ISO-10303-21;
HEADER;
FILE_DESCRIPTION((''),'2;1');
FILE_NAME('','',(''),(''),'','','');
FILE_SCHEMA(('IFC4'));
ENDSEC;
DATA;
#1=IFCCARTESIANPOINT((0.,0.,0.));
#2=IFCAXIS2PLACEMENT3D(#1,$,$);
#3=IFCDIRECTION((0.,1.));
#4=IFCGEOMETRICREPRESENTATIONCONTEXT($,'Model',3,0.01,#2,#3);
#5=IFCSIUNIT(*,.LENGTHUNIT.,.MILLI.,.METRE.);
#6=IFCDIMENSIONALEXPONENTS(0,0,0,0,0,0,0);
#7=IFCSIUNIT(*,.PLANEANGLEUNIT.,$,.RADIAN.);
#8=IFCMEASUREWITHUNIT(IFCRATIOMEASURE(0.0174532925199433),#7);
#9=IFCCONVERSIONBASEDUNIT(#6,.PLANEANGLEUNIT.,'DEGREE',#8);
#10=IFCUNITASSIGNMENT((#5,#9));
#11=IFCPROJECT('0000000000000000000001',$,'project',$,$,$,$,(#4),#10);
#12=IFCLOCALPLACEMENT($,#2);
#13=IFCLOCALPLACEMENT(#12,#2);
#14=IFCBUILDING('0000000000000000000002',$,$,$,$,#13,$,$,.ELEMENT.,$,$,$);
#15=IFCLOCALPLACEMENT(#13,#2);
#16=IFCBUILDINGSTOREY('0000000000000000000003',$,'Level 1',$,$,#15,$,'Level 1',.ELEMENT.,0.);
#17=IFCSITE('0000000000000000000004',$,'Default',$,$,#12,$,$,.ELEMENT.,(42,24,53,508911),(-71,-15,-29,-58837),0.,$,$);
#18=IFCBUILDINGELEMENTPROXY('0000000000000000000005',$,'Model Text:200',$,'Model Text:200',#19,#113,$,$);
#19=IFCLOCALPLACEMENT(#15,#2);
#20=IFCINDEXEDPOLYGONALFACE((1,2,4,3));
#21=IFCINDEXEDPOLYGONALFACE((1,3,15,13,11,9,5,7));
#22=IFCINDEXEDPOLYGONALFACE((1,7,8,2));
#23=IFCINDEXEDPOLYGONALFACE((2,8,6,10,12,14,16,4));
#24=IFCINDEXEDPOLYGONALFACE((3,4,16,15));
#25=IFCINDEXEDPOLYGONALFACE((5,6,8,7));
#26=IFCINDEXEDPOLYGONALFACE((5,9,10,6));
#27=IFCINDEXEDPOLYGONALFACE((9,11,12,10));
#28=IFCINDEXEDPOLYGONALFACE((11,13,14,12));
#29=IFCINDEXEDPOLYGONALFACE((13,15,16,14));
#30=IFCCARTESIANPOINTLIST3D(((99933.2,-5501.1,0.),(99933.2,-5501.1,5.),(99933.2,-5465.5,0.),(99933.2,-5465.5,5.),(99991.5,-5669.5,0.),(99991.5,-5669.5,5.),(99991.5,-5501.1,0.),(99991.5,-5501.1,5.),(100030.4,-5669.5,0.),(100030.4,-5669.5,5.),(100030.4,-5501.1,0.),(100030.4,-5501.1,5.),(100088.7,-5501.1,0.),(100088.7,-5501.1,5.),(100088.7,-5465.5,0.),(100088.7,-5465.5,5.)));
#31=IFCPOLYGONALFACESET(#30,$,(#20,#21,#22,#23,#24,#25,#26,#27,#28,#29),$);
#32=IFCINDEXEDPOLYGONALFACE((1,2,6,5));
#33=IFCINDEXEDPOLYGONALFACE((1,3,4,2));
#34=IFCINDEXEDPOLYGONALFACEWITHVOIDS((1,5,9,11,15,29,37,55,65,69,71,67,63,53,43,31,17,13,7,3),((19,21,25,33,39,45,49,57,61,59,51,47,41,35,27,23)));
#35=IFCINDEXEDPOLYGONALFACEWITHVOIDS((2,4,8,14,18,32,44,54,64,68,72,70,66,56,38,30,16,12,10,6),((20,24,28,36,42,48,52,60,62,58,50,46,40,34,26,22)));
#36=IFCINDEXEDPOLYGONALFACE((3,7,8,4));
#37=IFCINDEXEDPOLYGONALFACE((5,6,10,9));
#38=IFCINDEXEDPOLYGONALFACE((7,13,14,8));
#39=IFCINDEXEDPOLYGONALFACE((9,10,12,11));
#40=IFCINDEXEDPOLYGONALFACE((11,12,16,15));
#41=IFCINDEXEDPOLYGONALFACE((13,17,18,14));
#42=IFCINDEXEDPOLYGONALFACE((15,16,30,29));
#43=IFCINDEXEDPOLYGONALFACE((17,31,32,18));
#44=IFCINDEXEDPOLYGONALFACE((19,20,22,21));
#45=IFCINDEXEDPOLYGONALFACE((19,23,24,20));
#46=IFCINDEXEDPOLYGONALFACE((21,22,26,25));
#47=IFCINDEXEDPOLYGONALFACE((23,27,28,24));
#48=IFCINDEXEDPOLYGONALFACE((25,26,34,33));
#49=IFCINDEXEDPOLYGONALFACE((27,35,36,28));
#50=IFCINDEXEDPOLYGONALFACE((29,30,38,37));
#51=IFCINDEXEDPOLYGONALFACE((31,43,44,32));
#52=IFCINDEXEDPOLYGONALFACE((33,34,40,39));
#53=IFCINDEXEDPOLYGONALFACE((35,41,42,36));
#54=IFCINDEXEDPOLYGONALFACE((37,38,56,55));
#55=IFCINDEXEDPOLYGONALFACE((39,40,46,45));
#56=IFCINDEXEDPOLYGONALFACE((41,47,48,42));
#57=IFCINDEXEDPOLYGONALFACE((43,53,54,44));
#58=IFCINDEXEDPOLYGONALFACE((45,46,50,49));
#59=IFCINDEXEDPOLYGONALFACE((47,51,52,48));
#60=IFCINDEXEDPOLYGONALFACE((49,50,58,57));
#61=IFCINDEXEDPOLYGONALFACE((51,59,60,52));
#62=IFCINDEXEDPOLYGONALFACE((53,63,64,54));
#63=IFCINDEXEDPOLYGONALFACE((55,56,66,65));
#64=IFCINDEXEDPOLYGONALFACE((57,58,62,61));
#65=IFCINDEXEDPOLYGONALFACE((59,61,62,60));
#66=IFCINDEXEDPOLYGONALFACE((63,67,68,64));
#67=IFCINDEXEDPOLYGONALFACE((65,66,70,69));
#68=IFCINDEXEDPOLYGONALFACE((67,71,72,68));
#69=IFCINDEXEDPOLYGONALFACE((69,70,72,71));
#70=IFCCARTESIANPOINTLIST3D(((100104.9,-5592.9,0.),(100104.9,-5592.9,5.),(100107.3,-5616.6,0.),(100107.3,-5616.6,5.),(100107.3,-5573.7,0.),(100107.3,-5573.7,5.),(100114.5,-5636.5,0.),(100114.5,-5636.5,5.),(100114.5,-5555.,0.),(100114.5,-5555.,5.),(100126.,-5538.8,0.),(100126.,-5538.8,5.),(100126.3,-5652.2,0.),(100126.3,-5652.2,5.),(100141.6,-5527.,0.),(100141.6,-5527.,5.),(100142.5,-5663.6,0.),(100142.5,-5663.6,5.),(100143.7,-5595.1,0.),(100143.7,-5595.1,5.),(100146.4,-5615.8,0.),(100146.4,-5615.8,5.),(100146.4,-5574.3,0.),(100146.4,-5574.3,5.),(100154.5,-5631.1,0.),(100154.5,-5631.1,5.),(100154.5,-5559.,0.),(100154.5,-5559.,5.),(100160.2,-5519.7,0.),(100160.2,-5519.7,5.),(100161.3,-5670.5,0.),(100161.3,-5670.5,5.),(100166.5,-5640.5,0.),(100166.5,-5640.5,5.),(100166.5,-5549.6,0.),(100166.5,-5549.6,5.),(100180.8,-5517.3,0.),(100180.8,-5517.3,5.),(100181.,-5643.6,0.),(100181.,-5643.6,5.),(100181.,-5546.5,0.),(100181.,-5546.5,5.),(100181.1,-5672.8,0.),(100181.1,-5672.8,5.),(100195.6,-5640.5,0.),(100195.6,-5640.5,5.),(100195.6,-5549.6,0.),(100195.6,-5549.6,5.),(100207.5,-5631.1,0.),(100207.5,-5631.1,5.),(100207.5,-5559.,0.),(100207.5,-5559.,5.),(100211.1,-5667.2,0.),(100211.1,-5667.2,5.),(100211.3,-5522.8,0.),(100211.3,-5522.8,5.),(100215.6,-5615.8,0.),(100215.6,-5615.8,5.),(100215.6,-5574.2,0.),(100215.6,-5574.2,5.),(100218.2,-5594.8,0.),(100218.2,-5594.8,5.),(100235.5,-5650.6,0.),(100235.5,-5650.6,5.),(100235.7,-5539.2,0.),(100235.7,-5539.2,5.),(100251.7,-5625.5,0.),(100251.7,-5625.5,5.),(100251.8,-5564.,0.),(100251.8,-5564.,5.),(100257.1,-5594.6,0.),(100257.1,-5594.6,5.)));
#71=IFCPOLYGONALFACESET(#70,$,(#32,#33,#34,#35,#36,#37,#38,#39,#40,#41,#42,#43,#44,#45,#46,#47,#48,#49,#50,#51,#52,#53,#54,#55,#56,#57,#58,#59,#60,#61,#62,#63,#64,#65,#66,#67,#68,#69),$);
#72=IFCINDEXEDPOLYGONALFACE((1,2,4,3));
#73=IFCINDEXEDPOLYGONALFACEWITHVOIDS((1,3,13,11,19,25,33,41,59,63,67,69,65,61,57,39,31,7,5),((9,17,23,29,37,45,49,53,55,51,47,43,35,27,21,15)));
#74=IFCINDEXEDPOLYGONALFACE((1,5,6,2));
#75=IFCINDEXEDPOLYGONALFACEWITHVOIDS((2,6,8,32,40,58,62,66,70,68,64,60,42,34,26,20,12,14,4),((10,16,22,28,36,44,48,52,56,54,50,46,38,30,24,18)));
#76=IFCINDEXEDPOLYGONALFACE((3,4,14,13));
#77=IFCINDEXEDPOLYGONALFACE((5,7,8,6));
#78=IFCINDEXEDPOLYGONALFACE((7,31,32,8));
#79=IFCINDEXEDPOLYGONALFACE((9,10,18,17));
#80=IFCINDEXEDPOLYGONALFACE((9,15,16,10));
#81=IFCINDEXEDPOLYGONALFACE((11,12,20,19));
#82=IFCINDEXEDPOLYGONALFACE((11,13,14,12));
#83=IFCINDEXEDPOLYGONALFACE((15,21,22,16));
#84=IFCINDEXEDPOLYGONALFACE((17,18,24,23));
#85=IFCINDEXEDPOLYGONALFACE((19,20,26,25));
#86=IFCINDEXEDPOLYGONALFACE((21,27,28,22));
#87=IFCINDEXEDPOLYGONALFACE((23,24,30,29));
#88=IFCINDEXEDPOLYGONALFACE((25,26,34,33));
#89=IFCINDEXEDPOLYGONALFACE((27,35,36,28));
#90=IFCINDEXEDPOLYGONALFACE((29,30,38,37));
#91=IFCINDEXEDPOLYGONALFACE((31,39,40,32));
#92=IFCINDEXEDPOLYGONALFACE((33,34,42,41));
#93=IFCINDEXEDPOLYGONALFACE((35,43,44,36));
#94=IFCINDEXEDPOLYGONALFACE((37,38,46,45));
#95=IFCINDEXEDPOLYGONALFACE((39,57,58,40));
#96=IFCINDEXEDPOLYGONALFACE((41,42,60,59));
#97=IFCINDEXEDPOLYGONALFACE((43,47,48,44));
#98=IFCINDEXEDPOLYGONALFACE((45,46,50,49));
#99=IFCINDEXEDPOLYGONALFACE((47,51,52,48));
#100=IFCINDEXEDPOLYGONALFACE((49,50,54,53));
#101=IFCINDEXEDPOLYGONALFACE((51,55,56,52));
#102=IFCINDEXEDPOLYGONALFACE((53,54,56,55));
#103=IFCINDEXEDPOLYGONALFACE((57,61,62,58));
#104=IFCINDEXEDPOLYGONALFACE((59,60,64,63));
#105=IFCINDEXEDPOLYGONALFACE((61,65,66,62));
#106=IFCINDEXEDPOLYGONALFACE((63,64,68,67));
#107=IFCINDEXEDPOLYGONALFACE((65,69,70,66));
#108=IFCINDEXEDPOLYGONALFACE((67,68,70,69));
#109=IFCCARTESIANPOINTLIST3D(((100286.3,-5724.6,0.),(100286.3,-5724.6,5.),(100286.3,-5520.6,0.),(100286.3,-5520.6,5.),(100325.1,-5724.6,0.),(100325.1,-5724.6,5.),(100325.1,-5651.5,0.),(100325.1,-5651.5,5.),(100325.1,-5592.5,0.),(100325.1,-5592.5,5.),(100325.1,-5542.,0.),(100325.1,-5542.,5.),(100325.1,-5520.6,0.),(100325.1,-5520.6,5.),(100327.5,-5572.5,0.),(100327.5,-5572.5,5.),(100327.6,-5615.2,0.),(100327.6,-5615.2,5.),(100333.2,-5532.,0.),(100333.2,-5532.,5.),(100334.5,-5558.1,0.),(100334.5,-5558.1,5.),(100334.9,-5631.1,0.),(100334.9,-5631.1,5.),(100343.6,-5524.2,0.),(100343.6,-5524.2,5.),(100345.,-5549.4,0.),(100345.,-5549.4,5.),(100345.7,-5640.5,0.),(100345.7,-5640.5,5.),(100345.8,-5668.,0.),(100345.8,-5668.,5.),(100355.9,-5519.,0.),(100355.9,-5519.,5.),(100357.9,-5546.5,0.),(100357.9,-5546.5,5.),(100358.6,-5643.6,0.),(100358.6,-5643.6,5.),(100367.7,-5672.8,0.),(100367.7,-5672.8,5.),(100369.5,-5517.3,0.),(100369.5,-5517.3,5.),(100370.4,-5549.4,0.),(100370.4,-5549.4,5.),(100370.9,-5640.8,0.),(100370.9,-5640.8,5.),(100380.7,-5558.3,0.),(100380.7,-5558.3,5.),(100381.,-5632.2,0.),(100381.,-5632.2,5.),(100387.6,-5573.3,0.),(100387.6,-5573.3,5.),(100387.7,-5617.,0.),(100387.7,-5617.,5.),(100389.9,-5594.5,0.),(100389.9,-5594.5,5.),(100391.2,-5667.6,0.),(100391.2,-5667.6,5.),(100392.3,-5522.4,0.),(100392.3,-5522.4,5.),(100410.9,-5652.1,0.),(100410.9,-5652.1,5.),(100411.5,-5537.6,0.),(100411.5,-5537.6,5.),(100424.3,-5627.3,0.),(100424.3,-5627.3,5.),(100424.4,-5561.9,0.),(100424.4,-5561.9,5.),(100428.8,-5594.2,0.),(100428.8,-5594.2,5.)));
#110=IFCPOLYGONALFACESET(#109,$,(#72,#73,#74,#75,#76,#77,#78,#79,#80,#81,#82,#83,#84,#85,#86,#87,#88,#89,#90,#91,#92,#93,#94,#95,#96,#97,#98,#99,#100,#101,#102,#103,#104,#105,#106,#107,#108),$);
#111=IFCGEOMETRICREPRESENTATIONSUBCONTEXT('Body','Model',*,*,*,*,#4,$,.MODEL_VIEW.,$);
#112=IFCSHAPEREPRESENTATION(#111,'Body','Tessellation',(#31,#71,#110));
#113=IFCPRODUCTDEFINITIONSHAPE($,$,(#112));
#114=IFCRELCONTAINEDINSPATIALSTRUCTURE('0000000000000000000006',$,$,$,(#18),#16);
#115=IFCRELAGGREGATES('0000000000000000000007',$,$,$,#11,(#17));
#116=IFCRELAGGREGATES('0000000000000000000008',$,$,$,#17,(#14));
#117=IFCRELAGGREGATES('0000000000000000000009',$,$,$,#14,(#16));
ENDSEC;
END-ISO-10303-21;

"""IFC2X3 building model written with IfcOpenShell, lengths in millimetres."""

from ifc_helpers import new_model, entity, si_unit, converted_unit, direction, frame, origin, place, context, subcontext, project, spatial, polyline, outline, extrude, element, save


model = new_model("IFC2X3")

# Units and contexts
model_context = context("Model", 3, precision=0.01, world=origin(), true_north=direction((0.0, 1.0)))
body_context = subcontext(model_context, "Body", "Model", "MODEL_VIEW")
ifc_project = project(units=[si_unit("LENGTHUNIT", "METRE", prefix="MILLI"), converted_unit("PLANEANGLEUNIT", "DEGREE", entity("IfcRatioMeasure", 0.0174532925199433), si_unit("PLANEANGLEUNIT", "RADIAN"), dimensions=[0, 0, 0, 0, 0, 0, 0])], contexts=[model_context])

# Site, building, storey
site_placement = place(None, origin())
site = spatial("IfcSite", under=ifc_project, at=site_placement, Name="Default", CompositionType="ELEMENT", RefLatitude=(42, 24, 53, 508911), RefLongitude=(-71, -15, -29, -58837), RefElevation=0.0)
building_placement = place(site_placement, origin())
building = spatial("IfcBuilding", under=site, at=building_placement, CompositionType="ELEMENT")
storey_placement = place(building_placement, origin())
storey = spatial("IfcBuildingStorey", under=building, at=storey_placement, Name="Level 1", LongName="Level 1", CompositionType="ELEMENT", Elevation=0.0)

# Building element proxy
proxy_1_placement = place(storey_placement, origin())
element("IfcBuildingElementProxy", 1, at=proxy_1_placement, inside=storey, Name="Model Text:200", ObjectType="Model Text:200", context=body_context, shape_type="SweptSolid", body=[
    extrude(outline(polyline([(-19.4, -135.2), (19.4, -135.2), (19.4, 33.2), (77.7, 33.2), (77.7, 68.8), (-77.7, 68.8), (-77.7, 33.2), (-19.4, 33.2), (-19.4, -135.2)])), frame((100010.9, -5534.3, 0.0)), (0.0, 0.0, 1.0), 5.0),
    extrude(outline(polyline([(-8.8, -65.7), (15.1, -65.7), (35.5, -60.5), (52.3, -50.4), (65.3, -35.4), (74.1, -17.3), (78.4, 2.1), (75.9, 32.5), (61.8, 58.5), (38.4, 77.1), (8.3, 85.6), (-22.7, 83.3), (-49.0, 69.9), (-67.8, 47.3), (-76.3, 17.5), (-76.0, -3.3), (-70.7, -22.5), (-60.5, -39.2), (-45.5, -52.3), (-27.7, -61.4), (-8.8, -65.7)]), holes=[polyline([(-2.7, -27.2), (-23.1, -22.5), (-37.5, -12.9), (-45.7, 0.0), (-47.3, 14.8), (-42.7, 28.9), (-32.2, 39.9), (-16.3, 46.3), (4.5, 46.9), (25.1, 42.1), (39.6, 32.6), (47.7, 19.7), (49.4, 5.0), (44.8, -9.2), (34.2, -20.2), (18.2, -26.7), (-2.7, -27.2)])]), frame((100171.1, -5595.0, 0.0), z_axis=(0.0, 0.0, 1.0), x_axis=(0.100608, -0.994926, 0.0)), (0.0, 0.0, 1.0), 5.0),
    extrude(outline(polyline([(-73.1, -75.4), (130.9, -75.4), (130.9, -36.6), (57.8, -36.6), (74.3, -15.9), (79.1, 6.0), (73.9, 29.5), (58.4, 49.2), (33.6, 62.6), (0.5, 67.1), (-31.8, 62.8), (-56.1, 49.8), (-71.3, 30.7), (-76.4, 7.8), (-74.7, -5.8), (-69.6, -18.1), (-61.7, -28.5), (-51.7, -36.6), (-73.1, -36.6), (-73.1, -75.4)]), holes=[polyline([(-1.2, -36.6), (-21.2, -34.2), (-35.6, -27.2), (-44.3, -16.7), (-47.2, -3.8), (-44.3, 8.7), (-35.4, 19.0), (-20.4, 25.9), (0.8, 28.2), (23.3, 26.0), (38.5, 19.3), (47.1, 9.2), (49.9, -3.1), (46.8, -16.0), (37.4, -26.8), (21.5, -34.1), (-1.2, -36.6)])]), frame((100361.7, -5593.7, 0.0), z_axis=(0.0, 0.0, 1.0), x_axis=(0.0, -1.0, 0.0)), (0.0, 0.0, 1.0), 5.0),
])

save(model, "model.ifc")
